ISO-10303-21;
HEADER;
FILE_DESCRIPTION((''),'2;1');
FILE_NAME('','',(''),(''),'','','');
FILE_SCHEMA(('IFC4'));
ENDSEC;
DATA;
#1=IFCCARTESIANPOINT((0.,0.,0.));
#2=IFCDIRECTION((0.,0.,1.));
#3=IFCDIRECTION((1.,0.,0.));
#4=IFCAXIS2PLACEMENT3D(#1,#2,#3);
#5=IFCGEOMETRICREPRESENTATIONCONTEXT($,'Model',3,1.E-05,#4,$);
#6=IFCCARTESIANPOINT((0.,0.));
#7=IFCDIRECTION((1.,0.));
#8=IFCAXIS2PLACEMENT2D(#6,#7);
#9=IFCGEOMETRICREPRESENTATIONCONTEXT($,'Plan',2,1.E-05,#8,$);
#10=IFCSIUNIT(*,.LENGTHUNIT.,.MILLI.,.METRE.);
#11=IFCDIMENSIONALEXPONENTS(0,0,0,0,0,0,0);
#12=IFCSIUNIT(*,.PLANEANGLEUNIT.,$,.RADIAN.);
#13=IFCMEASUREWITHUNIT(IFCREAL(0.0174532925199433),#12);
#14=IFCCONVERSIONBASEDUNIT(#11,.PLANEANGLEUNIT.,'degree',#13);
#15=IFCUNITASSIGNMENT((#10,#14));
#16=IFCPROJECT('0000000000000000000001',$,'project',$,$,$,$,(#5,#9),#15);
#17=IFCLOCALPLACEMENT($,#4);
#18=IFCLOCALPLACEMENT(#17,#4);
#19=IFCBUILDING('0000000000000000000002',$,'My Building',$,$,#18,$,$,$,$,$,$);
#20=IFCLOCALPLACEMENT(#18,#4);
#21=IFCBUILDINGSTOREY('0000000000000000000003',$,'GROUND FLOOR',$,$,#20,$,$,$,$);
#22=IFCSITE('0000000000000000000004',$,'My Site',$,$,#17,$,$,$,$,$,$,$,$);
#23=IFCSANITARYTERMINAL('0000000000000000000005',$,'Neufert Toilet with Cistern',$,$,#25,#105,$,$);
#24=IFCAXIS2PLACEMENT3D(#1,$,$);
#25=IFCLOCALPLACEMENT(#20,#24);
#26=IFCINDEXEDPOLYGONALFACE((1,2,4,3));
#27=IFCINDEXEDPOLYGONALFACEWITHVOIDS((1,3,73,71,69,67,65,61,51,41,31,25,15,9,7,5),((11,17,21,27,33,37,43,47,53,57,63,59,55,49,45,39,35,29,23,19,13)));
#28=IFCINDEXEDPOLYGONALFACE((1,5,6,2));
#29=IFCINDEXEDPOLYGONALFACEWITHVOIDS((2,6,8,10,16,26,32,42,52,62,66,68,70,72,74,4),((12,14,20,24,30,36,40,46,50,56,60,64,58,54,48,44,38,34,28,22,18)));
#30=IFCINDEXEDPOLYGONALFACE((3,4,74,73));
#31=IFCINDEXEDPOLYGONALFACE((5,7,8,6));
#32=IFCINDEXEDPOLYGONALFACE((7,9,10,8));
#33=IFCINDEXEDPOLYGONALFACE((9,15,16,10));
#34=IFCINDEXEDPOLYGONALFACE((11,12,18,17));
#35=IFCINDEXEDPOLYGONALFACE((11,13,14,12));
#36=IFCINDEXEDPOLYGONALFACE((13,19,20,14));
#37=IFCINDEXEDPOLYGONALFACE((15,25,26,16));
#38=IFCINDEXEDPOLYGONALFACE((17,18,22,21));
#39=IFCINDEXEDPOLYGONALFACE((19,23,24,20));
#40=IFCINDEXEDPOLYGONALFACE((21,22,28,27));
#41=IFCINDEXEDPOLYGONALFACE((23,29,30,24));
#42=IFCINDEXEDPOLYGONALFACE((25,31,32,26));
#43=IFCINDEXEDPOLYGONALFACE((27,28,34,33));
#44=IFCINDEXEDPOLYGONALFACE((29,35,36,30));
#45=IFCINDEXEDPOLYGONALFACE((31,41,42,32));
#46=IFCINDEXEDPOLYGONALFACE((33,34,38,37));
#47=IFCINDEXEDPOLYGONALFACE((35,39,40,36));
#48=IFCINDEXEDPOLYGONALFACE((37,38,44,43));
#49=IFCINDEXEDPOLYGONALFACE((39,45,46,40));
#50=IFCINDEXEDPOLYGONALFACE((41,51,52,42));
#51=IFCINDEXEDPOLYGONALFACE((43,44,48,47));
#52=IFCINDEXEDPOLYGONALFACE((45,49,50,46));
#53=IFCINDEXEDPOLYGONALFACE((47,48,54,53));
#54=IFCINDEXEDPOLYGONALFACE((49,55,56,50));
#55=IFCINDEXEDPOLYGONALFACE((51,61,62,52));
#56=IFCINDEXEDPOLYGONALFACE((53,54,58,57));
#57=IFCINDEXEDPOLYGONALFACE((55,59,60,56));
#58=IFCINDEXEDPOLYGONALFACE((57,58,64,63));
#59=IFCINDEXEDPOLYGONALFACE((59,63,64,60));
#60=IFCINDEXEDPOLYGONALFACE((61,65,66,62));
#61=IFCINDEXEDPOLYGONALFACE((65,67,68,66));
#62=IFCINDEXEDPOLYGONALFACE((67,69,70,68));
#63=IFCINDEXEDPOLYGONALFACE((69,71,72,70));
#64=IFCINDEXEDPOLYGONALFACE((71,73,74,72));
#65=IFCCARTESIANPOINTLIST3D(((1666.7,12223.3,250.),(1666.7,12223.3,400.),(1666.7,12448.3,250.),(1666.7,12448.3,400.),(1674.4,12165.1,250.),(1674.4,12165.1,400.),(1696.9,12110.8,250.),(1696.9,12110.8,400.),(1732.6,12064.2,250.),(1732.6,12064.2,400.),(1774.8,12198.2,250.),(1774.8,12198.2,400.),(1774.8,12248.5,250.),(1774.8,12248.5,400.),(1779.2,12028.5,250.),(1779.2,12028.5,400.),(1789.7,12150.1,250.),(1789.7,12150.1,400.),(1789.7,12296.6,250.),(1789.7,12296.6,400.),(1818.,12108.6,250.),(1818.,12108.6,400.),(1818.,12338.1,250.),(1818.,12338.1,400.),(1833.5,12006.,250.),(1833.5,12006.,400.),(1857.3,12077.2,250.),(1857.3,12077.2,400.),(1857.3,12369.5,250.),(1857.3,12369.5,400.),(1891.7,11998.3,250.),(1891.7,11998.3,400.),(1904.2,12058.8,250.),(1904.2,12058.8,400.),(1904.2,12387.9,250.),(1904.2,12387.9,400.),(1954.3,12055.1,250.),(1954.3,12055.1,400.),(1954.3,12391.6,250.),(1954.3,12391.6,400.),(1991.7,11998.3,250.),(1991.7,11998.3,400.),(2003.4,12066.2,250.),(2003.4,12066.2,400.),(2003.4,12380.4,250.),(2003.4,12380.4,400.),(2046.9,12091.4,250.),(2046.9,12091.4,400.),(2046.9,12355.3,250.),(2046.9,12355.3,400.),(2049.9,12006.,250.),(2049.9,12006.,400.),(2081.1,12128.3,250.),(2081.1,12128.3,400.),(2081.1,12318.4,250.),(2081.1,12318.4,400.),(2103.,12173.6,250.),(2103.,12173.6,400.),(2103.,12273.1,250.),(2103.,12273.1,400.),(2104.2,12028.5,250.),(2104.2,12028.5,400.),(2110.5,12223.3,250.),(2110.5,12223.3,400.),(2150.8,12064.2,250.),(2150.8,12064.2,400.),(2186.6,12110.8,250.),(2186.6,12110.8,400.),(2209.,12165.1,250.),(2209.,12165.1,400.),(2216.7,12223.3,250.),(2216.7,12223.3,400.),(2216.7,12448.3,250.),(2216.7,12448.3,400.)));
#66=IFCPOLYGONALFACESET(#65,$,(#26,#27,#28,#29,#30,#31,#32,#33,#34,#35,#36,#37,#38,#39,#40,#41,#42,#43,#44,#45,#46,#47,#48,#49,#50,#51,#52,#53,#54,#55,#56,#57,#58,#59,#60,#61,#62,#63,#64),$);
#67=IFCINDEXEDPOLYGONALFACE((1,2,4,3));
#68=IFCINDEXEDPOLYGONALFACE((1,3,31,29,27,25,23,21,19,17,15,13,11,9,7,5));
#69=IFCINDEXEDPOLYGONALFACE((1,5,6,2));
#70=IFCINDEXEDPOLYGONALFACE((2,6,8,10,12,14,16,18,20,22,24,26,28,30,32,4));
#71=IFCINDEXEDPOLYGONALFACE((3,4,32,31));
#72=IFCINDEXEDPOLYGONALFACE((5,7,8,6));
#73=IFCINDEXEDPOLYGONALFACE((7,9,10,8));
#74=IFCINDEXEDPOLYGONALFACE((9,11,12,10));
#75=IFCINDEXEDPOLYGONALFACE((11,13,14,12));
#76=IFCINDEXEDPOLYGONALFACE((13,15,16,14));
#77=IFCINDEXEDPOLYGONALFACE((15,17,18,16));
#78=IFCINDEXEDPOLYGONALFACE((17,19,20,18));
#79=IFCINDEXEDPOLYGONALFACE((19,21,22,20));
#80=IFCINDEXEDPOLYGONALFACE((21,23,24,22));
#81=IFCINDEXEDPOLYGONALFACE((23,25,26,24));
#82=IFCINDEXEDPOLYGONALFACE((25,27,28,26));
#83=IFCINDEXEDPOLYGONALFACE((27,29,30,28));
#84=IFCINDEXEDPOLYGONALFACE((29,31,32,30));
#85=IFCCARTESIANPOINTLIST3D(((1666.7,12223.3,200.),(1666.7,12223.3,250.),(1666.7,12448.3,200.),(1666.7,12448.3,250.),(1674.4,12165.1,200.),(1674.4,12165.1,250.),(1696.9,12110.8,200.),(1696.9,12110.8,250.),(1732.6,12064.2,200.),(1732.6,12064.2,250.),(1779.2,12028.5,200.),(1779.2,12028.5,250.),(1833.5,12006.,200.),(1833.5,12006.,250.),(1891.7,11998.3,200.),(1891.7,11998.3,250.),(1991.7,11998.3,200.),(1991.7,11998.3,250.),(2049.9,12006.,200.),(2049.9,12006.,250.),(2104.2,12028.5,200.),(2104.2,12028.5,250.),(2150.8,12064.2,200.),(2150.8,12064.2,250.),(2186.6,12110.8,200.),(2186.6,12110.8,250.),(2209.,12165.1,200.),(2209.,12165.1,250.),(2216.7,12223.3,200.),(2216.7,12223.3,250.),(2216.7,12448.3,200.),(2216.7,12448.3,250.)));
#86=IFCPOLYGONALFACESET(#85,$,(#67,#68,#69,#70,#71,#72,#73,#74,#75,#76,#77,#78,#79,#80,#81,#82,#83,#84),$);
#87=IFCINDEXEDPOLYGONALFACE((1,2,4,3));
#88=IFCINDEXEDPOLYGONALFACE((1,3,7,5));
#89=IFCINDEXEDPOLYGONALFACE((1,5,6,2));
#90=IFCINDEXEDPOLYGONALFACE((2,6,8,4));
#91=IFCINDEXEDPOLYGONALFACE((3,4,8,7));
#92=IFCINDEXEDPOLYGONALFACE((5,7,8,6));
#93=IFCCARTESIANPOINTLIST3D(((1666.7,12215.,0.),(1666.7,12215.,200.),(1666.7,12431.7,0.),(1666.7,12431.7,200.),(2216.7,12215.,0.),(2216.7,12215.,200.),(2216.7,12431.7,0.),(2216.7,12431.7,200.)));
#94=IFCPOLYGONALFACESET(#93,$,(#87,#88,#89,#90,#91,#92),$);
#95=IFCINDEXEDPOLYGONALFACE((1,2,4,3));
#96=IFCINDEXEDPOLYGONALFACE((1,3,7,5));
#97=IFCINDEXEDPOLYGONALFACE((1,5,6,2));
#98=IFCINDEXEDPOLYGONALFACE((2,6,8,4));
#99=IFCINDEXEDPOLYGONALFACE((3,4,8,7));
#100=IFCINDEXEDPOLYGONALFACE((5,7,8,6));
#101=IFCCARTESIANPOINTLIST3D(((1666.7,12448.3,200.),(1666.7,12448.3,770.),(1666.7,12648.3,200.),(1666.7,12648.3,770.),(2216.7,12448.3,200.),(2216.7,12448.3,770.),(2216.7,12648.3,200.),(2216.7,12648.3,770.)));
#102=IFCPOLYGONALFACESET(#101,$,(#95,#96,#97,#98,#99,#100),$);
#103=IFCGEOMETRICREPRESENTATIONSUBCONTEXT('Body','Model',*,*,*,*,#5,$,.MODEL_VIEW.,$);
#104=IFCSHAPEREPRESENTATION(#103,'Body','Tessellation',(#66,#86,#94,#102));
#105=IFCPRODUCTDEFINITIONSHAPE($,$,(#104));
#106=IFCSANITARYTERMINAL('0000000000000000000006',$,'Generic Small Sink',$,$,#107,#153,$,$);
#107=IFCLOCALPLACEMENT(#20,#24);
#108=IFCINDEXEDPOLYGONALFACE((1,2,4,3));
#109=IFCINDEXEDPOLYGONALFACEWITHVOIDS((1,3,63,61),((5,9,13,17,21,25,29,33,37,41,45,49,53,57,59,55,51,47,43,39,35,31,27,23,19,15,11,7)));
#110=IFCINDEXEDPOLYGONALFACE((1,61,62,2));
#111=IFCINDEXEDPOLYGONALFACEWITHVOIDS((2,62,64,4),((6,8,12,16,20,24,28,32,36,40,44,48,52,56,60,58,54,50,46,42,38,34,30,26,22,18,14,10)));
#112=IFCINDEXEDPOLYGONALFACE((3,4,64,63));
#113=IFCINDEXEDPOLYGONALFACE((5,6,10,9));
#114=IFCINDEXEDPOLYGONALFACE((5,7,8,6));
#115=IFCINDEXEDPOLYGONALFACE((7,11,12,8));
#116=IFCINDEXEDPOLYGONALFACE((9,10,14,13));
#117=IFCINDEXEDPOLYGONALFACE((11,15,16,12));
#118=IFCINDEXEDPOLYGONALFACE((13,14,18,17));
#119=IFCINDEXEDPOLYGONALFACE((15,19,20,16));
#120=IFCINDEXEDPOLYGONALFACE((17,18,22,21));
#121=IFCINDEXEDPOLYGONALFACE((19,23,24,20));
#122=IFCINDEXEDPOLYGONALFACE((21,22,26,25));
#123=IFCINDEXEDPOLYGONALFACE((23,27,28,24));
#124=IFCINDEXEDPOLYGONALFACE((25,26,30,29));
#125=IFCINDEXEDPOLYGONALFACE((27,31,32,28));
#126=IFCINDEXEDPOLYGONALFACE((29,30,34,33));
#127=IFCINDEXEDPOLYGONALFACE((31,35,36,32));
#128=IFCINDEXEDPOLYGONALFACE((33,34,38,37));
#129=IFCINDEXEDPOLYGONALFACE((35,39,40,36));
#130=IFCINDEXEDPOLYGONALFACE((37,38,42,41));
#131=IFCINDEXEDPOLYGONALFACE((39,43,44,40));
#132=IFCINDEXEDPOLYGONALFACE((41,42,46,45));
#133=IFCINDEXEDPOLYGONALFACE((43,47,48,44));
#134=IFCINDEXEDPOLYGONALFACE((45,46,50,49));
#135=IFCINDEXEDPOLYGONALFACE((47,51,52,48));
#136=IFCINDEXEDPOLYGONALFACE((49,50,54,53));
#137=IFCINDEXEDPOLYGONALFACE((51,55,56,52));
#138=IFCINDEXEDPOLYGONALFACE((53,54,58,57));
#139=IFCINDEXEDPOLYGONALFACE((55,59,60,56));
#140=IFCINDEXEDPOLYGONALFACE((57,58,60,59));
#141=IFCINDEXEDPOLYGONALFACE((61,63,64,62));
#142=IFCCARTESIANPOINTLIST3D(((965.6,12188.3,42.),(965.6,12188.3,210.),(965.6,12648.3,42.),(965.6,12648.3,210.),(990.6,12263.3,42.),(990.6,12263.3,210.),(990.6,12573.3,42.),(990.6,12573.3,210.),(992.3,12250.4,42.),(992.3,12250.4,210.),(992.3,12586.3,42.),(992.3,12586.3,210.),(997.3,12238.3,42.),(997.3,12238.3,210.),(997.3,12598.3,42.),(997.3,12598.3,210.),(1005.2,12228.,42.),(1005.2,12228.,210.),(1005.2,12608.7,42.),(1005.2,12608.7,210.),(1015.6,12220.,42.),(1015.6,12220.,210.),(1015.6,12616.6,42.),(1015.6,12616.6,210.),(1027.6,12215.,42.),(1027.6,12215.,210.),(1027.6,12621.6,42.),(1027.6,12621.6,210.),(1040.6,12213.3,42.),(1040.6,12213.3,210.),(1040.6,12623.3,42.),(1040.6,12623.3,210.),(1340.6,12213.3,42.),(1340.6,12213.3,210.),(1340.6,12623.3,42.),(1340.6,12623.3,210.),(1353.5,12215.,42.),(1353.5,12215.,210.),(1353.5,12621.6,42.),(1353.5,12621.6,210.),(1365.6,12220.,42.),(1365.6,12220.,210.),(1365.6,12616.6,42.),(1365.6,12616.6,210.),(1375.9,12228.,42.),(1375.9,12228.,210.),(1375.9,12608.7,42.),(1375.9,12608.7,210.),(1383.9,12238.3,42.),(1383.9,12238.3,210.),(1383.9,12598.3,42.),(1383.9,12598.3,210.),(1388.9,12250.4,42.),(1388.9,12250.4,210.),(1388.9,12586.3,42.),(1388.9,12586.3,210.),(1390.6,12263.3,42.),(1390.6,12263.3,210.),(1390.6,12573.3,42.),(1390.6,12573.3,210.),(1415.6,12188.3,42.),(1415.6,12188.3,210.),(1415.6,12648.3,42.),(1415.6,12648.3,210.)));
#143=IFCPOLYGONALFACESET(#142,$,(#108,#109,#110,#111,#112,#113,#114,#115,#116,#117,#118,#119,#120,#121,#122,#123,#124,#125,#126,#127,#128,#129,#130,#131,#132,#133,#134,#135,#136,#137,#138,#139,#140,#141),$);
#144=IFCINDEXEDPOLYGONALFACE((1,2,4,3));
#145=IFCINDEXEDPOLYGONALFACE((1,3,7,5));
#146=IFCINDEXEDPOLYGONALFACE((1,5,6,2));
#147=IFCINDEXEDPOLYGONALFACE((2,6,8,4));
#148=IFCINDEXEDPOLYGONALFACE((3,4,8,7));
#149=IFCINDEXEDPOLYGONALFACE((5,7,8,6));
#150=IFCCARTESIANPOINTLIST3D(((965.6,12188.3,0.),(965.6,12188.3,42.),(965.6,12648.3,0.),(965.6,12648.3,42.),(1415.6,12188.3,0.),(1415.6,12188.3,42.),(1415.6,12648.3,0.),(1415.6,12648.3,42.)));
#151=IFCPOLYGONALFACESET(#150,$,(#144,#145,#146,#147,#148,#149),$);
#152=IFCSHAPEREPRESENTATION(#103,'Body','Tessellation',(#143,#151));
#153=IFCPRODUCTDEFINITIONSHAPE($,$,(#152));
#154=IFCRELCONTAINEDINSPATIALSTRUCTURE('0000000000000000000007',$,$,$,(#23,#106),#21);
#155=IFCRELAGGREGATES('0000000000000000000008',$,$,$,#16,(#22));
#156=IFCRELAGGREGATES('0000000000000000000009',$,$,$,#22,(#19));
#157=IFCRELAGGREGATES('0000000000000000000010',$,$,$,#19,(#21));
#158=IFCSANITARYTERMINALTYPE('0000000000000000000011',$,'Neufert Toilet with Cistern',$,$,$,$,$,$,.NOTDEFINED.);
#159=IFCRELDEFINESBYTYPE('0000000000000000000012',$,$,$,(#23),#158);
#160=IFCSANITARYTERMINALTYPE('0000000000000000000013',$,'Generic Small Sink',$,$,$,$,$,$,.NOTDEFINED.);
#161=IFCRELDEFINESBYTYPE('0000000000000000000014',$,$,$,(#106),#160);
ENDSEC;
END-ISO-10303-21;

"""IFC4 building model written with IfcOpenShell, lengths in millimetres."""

from ifc_helpers import new_model, entity, si_unit, converted_unit, frame, frame_2d, origin_with_axes, origin_2d_with_axis, place, context, subcontext, project, spatial, line, arc, indexed_curve, circle_curve, outline, extrude, shape, source, transform, mapped, type_object, type_shapes, element, save


model = new_model("IFC4")

# Units and contexts
model_context = context("Model", 3, precision=1e-05, world=origin_with_axes())
plan_context = context("Plan", 2, precision=1e-05, world=origin_2d_with_axis())
body_context_1 = subcontext(model_context, "Body", "Model", "MODEL_VIEW")
body_context_2 = subcontext(plan_context, "Body", "Plan", "PLAN_VIEW")
ifc_project = project(units=[si_unit("LENGTHUNIT", "METRE", prefix="MILLI"), converted_unit("PLANEANGLEUNIT", "degree", entity("IfcReal", 0.0174532925199433), si_unit("PLANEANGLEUNIT", "RADIAN"), dimensions=[0, 0, 0, 0, 0, 0, 0])], contexts=[model_context, plan_context])

# Site, building, storey
site_placement = place(None, origin_with_axes())
site = spatial("IfcSite", under=ifc_project, at=site_placement, Name="My Site")
building_placement = place(site_placement, origin_with_axes())
building = spatial("IfcBuilding", under=site, at=building_placement, Name="My Building")
storey_placement = place(building_placement, origin_with_axes())
storey = spatial("IfcBuildingStorey", under=building, at=storey_placement, Name="GROUND FLOOR")

# Sanitary terminals
sanitary_terminal_type_1 = type_object("IfcSanitaryTerminalType", Name="Neufert Toilet with Cistern", PredefinedType="NOTDEFINED")
shared_shape_1 = source(origin_with_axes(), body_context_1, "Body", "SweptSolid", [
    extrude(outline(indexed_curve([(-275.0, -200.0), (275.0, -200.0), (275.0, -425.0), (209.1, -584.1), (50.0, -650.0), (-50.0, -650.0), (-209.1, -584.1), (-275.0, -425.0)], segments=[line(1, 2), line(2, 3), arc(3, 4, 5), line(5, 6), arc(6, 7, 8), line(8, 1)]), holes=[circle_curve(frame_2d((0.0, -425.0)), 168.8)]), frame((0.0, 0.0, 250.0), z_axis=(0.0, 0.0, 1.0), x_axis=(1.0, 0.0, 0.0)), (0.0, 0.0, 1.0), 150.0),
    extrude(outline(indexed_curve([(-275.0, -200.0), (275.0, -200.0), (275.0, -425.0), (209.1, -584.1), (50.0, -650.0), (-50.0, -650.0), (-209.1, -584.1), (-275.0, -425.0)], segments=[line(1, 2), line(2, 3), arc(3, 4, 5), line(5, 6), arc(6, 7, 8), line(8, 1)])), frame((0.0, 0.0, 200.0), z_axis=(0.0, 0.0, 1.0), x_axis=(1.0, 0.0, 0.0)), (0.0, 0.0, 1.0), 50.0),
    extrude(outline(indexed_curve([(-275.0, -216.7), (275.0, -216.7), (275.0, -433.3), (-275.0, -433.3)], segments=[line(1, 2, 3, 4, 1)])), origin_with_axes(), (0.0, 0.0, 1.0), 200.0),
    extrude(outline(indexed_curve([(-275.0, 0.0), (275.0, 0.0), (275.0, -200.0), (-275.0, -200.0)], segments=[line(1, 2, 3, 4, 1)])), frame((0.0, 0.0, 200.0), z_axis=(0.0, 0.0, 1.0), x_axis=(1.0, 0.0, 0.0)), (0.0, 0.0, 1.0), 570.0),
])
shared_shape_2 = source(origin_with_axes(), body_context_2, "Body", "Curve2D", [
    entity("IfcIndexedPolyCurve", entity("IfcCartesianPointList2D", [[-275.0, 0.0], [275.0, 0.0], [275.0, -200.0], [-275.0, -200.0]]), [entity("IfcLineIndex", [1, 2, 3, 4, 1])]),
    entity("IfcIndexedPolyCurve", entity("IfcCartesianPointList2D", [[165.0, -200.0], [192.5, -335.0]])),
    entity("IfcTrimmedCurve", entity("IfcEllipse", entity("IfcAxis2Placement2D", entity("IfcCartesianPoint", [0.0, -335.0]), entity("IfcDirection", [1.0, 0.0])), 192.5, 315.0), [entity("IfcCartesianPoint", [-192.5, -335.0])], [entity("IfcCartesianPoint", [192.5, -335.0])], True, "CARTESIAN"),
    entity("IfcIndexedPolyCurve", entity("IfcCartesianPointList2D", [[-165.0, -200.0], [-192.5, -335.0]])),
    entity("IfcEllipse", entity("IfcAxis2Placement2D", entity("IfcCartesianPoint", [0.0, -452.0]), entity("IfcDirection", [1.0, 0.0])), 131.2, 157.5),
    entity("IfcIndexedPolyCurve", entity("IfcCartesianPointList2D", [[-34.4, -452.0], [-34.4, -429.5], [34.4, -429.5], [34.4, -452.0]])),
    entity("IfcTrimmedCurve", entity("IfcEllipse", entity("IfcAxis2Placement2D", entity("IfcCartesianPoint", [0.0, -452.0]), entity("IfcDirection", [1.0, 0.0])), 34.4, 22.5), [entity("IfcCartesianPoint", [-34.4, -452.0])], [entity("IfcCartesianPoint", [34.4, -452.0])], True, "CARTESIAN"),
])
type_shapes(sanitary_terminal_type_1, [shared_shape_1, shared_shape_2])
sanitary_terminal_1_placement = place(storey_placement, frame((1941.7, 12648.3, 0.0), z_axis=(0.0, 0.0, 1.0), x_axis=(1.0, 0.0, 0.0)))
element("IfcSanitaryTerminal", 1, at=sanitary_terminal_1_placement, inside=storey, type_object=sanitary_terminal_type_1, Name="Neufert Toilet with Cistern", shapes=[
    shape(body_context_1, "Body", "MappedRepresentation", [mapped(shared_shape_1, transform((0.0, 0.0, 0.0), x_axis=(1.0, 0.0, 0.0), y_axis=(0.0, 1.0, 0.0), z_axis=(0.0, 0.0, 1.0), scale=1.0))]),
    shape(body_context_2, "Body", "MappedRepresentation", [mapped(shared_shape_2, transform((0.0, 0.0, 0.0), x_axis=(1.0, 0.0, 0.0), y_axis=(0.0, 1.0, 0.0), z_axis=(0.0, 0.0, 1.0), scale=1.0))]),
])
sanitary_terminal_type_2 = type_object("IfcSanitaryTerminalType", Name="Generic Small Sink", PredefinedType="NOTDEFINED")
shared_indexed_poly_curve = entity("IfcIndexedPolyCurve", entity("IfcCartesianPointList2D", [[0.0, 0.0], [450.0, 0.0], [450.0, 460.0], [0.0, 460.0]]), [entity("IfcLineIndex", [1, 2, 3, 4, 1])])
shared_shape_3 = source(origin_with_axes(), body_context_1, "Body", "SweptSolid", [
    entity("IfcExtrudedAreaSolid", entity("IfcArbitraryProfileDefWithVoids", "AREA", None, shared_indexed_poly_curve, [entity("IfcIndexedPolyCurve", entity("IfcCartesianPointList2D", [[25.0, 75.0], [39.6, 39.6], [75.0, 25.0], [375.0, 25.0], [410.4, 39.6], [425.0, 75.0], [425.0, 385.0], [410.4, 420.4], [375.0, 435.0], [75.0, 435.0], [39.6, 420.4], [25.0, 385.0]]), [entity("IfcLineIndex", [12, 1]), entity("IfcArcIndex", [1, 2, 3]), entity("IfcLineIndex", [3, 4]), entity("IfcArcIndex", [4, 5, 6]), entity("IfcLineIndex", [6, 7]), entity("IfcArcIndex", [7, 8, 9]), entity("IfcLineIndex", [9, 10]), entity("IfcArcIndex", [10, 11, 12]), entity("IfcLineIndex", [12, 1])])]), entity("IfcAxis2Placement3D", entity("IfcCartesianPoint", [-225.0, -460.0, 42.0]), entity("IfcDirection", [0.0, 0.0, 1.0]), entity("IfcDirection", [1.0, 0.0, 0.0])), entity("IfcDirection", [0.0, 0.0, 1.0]), 168.0),
    entity("IfcExtrudedAreaSolid", entity("IfcArbitraryClosedProfileDef", "AREA", None, shared_indexed_poly_curve), entity("IfcAxis2Placement3D", entity("IfcCartesianPoint", [-225.0, -460.0, 0.0]), entity("IfcDirection", [0.0, 0.0, 1.0]), entity("IfcDirection", [1.0, 0.0, 0.0])), entity("IfcDirection", [0.0, 0.0, 1.0]), 42.0),
])
shared_shape_4 = source(origin_with_axes(), body_context_2, "Body", "Curve2D", [
    entity("IfcIndexedPolyCurve", entity("IfcCartesianPointList2D", [[-225.0, -460.0], [225.0, -460.0], [225.0, 0.0], [-225.0, 0.0]]), [entity("IfcLineIndex", [1, 2, 3, 4, 1])]),
    entity("IfcIndexedPolyCurve", entity("IfcCartesianPointList2D", [[-200.0, -385.0], [-185.4, -420.4], [-150.0, -435.0], [150.0, -435.0], [185.4, -420.4], [200.0, -385.0], [200.0, -75.0], [185.4, -39.6], [150.0, -25.0], [-150.0, -25.0], [-185.4, -39.6], [-200.0, -75.0]]), [entity("IfcLineIndex", [12, 1]), entity("IfcArcIndex", [1, 2, 3]), entity("IfcLineIndex", [3, 4]), entity("IfcArcIndex", [4, 5, 6]), entity("IfcLineIndex", [6, 7]), entity("IfcArcIndex", [7, 8, 9]), entity("IfcLineIndex", [9, 10]), entity("IfcArcIndex", [10, 11, 12]), entity("IfcLineIndex", [12, 1])]),
    entity("IfcCircle", entity("IfcAxis2Placement2D", entity("IfcCartesianPoint", [0.0, -125.0])), 25.0),
    entity("IfcIndexedPolyCurve", entity("IfcCartesianPointList2D", [[0.0, -12.5], [0.0, -132.5]])),
])
type_shapes(sanitary_terminal_type_2, [shared_shape_3, shared_shape_4])
sanitary_terminal_2_placement = place(storey_placement, frame((1190.6, 12648.3, 0.0), z_axis=(0.0, 0.0, 1.0), x_axis=(1.0, 0.0, 0.0)))
element("IfcSanitaryTerminal", 2, at=sanitary_terminal_2_placement, inside=storey, type_object=sanitary_terminal_type_2, Name="Generic Small Sink", shapes=[
    shape(body_context_1, "Body", "MappedRepresentation", [mapped(shared_shape_3, transform((0.0, 0.0, 0.0), x_axis=(1.0, 0.0, 0.0), y_axis=(0.0, 1.0, 0.0), z_axis=(0.0, 0.0, 1.0), scale=1.0))]),
    shape(body_context_2, "Body", "MappedRepresentation", [mapped(shared_shape_4, transform((0.0, 0.0, 0.0), x_axis=(1.0, 0.0, 0.0), y_axis=(0.0, 1.0, 0.0), z_axis=(0.0, 0.0, 1.0), scale=1.0))]),
])

save(model, "model.ifc")
